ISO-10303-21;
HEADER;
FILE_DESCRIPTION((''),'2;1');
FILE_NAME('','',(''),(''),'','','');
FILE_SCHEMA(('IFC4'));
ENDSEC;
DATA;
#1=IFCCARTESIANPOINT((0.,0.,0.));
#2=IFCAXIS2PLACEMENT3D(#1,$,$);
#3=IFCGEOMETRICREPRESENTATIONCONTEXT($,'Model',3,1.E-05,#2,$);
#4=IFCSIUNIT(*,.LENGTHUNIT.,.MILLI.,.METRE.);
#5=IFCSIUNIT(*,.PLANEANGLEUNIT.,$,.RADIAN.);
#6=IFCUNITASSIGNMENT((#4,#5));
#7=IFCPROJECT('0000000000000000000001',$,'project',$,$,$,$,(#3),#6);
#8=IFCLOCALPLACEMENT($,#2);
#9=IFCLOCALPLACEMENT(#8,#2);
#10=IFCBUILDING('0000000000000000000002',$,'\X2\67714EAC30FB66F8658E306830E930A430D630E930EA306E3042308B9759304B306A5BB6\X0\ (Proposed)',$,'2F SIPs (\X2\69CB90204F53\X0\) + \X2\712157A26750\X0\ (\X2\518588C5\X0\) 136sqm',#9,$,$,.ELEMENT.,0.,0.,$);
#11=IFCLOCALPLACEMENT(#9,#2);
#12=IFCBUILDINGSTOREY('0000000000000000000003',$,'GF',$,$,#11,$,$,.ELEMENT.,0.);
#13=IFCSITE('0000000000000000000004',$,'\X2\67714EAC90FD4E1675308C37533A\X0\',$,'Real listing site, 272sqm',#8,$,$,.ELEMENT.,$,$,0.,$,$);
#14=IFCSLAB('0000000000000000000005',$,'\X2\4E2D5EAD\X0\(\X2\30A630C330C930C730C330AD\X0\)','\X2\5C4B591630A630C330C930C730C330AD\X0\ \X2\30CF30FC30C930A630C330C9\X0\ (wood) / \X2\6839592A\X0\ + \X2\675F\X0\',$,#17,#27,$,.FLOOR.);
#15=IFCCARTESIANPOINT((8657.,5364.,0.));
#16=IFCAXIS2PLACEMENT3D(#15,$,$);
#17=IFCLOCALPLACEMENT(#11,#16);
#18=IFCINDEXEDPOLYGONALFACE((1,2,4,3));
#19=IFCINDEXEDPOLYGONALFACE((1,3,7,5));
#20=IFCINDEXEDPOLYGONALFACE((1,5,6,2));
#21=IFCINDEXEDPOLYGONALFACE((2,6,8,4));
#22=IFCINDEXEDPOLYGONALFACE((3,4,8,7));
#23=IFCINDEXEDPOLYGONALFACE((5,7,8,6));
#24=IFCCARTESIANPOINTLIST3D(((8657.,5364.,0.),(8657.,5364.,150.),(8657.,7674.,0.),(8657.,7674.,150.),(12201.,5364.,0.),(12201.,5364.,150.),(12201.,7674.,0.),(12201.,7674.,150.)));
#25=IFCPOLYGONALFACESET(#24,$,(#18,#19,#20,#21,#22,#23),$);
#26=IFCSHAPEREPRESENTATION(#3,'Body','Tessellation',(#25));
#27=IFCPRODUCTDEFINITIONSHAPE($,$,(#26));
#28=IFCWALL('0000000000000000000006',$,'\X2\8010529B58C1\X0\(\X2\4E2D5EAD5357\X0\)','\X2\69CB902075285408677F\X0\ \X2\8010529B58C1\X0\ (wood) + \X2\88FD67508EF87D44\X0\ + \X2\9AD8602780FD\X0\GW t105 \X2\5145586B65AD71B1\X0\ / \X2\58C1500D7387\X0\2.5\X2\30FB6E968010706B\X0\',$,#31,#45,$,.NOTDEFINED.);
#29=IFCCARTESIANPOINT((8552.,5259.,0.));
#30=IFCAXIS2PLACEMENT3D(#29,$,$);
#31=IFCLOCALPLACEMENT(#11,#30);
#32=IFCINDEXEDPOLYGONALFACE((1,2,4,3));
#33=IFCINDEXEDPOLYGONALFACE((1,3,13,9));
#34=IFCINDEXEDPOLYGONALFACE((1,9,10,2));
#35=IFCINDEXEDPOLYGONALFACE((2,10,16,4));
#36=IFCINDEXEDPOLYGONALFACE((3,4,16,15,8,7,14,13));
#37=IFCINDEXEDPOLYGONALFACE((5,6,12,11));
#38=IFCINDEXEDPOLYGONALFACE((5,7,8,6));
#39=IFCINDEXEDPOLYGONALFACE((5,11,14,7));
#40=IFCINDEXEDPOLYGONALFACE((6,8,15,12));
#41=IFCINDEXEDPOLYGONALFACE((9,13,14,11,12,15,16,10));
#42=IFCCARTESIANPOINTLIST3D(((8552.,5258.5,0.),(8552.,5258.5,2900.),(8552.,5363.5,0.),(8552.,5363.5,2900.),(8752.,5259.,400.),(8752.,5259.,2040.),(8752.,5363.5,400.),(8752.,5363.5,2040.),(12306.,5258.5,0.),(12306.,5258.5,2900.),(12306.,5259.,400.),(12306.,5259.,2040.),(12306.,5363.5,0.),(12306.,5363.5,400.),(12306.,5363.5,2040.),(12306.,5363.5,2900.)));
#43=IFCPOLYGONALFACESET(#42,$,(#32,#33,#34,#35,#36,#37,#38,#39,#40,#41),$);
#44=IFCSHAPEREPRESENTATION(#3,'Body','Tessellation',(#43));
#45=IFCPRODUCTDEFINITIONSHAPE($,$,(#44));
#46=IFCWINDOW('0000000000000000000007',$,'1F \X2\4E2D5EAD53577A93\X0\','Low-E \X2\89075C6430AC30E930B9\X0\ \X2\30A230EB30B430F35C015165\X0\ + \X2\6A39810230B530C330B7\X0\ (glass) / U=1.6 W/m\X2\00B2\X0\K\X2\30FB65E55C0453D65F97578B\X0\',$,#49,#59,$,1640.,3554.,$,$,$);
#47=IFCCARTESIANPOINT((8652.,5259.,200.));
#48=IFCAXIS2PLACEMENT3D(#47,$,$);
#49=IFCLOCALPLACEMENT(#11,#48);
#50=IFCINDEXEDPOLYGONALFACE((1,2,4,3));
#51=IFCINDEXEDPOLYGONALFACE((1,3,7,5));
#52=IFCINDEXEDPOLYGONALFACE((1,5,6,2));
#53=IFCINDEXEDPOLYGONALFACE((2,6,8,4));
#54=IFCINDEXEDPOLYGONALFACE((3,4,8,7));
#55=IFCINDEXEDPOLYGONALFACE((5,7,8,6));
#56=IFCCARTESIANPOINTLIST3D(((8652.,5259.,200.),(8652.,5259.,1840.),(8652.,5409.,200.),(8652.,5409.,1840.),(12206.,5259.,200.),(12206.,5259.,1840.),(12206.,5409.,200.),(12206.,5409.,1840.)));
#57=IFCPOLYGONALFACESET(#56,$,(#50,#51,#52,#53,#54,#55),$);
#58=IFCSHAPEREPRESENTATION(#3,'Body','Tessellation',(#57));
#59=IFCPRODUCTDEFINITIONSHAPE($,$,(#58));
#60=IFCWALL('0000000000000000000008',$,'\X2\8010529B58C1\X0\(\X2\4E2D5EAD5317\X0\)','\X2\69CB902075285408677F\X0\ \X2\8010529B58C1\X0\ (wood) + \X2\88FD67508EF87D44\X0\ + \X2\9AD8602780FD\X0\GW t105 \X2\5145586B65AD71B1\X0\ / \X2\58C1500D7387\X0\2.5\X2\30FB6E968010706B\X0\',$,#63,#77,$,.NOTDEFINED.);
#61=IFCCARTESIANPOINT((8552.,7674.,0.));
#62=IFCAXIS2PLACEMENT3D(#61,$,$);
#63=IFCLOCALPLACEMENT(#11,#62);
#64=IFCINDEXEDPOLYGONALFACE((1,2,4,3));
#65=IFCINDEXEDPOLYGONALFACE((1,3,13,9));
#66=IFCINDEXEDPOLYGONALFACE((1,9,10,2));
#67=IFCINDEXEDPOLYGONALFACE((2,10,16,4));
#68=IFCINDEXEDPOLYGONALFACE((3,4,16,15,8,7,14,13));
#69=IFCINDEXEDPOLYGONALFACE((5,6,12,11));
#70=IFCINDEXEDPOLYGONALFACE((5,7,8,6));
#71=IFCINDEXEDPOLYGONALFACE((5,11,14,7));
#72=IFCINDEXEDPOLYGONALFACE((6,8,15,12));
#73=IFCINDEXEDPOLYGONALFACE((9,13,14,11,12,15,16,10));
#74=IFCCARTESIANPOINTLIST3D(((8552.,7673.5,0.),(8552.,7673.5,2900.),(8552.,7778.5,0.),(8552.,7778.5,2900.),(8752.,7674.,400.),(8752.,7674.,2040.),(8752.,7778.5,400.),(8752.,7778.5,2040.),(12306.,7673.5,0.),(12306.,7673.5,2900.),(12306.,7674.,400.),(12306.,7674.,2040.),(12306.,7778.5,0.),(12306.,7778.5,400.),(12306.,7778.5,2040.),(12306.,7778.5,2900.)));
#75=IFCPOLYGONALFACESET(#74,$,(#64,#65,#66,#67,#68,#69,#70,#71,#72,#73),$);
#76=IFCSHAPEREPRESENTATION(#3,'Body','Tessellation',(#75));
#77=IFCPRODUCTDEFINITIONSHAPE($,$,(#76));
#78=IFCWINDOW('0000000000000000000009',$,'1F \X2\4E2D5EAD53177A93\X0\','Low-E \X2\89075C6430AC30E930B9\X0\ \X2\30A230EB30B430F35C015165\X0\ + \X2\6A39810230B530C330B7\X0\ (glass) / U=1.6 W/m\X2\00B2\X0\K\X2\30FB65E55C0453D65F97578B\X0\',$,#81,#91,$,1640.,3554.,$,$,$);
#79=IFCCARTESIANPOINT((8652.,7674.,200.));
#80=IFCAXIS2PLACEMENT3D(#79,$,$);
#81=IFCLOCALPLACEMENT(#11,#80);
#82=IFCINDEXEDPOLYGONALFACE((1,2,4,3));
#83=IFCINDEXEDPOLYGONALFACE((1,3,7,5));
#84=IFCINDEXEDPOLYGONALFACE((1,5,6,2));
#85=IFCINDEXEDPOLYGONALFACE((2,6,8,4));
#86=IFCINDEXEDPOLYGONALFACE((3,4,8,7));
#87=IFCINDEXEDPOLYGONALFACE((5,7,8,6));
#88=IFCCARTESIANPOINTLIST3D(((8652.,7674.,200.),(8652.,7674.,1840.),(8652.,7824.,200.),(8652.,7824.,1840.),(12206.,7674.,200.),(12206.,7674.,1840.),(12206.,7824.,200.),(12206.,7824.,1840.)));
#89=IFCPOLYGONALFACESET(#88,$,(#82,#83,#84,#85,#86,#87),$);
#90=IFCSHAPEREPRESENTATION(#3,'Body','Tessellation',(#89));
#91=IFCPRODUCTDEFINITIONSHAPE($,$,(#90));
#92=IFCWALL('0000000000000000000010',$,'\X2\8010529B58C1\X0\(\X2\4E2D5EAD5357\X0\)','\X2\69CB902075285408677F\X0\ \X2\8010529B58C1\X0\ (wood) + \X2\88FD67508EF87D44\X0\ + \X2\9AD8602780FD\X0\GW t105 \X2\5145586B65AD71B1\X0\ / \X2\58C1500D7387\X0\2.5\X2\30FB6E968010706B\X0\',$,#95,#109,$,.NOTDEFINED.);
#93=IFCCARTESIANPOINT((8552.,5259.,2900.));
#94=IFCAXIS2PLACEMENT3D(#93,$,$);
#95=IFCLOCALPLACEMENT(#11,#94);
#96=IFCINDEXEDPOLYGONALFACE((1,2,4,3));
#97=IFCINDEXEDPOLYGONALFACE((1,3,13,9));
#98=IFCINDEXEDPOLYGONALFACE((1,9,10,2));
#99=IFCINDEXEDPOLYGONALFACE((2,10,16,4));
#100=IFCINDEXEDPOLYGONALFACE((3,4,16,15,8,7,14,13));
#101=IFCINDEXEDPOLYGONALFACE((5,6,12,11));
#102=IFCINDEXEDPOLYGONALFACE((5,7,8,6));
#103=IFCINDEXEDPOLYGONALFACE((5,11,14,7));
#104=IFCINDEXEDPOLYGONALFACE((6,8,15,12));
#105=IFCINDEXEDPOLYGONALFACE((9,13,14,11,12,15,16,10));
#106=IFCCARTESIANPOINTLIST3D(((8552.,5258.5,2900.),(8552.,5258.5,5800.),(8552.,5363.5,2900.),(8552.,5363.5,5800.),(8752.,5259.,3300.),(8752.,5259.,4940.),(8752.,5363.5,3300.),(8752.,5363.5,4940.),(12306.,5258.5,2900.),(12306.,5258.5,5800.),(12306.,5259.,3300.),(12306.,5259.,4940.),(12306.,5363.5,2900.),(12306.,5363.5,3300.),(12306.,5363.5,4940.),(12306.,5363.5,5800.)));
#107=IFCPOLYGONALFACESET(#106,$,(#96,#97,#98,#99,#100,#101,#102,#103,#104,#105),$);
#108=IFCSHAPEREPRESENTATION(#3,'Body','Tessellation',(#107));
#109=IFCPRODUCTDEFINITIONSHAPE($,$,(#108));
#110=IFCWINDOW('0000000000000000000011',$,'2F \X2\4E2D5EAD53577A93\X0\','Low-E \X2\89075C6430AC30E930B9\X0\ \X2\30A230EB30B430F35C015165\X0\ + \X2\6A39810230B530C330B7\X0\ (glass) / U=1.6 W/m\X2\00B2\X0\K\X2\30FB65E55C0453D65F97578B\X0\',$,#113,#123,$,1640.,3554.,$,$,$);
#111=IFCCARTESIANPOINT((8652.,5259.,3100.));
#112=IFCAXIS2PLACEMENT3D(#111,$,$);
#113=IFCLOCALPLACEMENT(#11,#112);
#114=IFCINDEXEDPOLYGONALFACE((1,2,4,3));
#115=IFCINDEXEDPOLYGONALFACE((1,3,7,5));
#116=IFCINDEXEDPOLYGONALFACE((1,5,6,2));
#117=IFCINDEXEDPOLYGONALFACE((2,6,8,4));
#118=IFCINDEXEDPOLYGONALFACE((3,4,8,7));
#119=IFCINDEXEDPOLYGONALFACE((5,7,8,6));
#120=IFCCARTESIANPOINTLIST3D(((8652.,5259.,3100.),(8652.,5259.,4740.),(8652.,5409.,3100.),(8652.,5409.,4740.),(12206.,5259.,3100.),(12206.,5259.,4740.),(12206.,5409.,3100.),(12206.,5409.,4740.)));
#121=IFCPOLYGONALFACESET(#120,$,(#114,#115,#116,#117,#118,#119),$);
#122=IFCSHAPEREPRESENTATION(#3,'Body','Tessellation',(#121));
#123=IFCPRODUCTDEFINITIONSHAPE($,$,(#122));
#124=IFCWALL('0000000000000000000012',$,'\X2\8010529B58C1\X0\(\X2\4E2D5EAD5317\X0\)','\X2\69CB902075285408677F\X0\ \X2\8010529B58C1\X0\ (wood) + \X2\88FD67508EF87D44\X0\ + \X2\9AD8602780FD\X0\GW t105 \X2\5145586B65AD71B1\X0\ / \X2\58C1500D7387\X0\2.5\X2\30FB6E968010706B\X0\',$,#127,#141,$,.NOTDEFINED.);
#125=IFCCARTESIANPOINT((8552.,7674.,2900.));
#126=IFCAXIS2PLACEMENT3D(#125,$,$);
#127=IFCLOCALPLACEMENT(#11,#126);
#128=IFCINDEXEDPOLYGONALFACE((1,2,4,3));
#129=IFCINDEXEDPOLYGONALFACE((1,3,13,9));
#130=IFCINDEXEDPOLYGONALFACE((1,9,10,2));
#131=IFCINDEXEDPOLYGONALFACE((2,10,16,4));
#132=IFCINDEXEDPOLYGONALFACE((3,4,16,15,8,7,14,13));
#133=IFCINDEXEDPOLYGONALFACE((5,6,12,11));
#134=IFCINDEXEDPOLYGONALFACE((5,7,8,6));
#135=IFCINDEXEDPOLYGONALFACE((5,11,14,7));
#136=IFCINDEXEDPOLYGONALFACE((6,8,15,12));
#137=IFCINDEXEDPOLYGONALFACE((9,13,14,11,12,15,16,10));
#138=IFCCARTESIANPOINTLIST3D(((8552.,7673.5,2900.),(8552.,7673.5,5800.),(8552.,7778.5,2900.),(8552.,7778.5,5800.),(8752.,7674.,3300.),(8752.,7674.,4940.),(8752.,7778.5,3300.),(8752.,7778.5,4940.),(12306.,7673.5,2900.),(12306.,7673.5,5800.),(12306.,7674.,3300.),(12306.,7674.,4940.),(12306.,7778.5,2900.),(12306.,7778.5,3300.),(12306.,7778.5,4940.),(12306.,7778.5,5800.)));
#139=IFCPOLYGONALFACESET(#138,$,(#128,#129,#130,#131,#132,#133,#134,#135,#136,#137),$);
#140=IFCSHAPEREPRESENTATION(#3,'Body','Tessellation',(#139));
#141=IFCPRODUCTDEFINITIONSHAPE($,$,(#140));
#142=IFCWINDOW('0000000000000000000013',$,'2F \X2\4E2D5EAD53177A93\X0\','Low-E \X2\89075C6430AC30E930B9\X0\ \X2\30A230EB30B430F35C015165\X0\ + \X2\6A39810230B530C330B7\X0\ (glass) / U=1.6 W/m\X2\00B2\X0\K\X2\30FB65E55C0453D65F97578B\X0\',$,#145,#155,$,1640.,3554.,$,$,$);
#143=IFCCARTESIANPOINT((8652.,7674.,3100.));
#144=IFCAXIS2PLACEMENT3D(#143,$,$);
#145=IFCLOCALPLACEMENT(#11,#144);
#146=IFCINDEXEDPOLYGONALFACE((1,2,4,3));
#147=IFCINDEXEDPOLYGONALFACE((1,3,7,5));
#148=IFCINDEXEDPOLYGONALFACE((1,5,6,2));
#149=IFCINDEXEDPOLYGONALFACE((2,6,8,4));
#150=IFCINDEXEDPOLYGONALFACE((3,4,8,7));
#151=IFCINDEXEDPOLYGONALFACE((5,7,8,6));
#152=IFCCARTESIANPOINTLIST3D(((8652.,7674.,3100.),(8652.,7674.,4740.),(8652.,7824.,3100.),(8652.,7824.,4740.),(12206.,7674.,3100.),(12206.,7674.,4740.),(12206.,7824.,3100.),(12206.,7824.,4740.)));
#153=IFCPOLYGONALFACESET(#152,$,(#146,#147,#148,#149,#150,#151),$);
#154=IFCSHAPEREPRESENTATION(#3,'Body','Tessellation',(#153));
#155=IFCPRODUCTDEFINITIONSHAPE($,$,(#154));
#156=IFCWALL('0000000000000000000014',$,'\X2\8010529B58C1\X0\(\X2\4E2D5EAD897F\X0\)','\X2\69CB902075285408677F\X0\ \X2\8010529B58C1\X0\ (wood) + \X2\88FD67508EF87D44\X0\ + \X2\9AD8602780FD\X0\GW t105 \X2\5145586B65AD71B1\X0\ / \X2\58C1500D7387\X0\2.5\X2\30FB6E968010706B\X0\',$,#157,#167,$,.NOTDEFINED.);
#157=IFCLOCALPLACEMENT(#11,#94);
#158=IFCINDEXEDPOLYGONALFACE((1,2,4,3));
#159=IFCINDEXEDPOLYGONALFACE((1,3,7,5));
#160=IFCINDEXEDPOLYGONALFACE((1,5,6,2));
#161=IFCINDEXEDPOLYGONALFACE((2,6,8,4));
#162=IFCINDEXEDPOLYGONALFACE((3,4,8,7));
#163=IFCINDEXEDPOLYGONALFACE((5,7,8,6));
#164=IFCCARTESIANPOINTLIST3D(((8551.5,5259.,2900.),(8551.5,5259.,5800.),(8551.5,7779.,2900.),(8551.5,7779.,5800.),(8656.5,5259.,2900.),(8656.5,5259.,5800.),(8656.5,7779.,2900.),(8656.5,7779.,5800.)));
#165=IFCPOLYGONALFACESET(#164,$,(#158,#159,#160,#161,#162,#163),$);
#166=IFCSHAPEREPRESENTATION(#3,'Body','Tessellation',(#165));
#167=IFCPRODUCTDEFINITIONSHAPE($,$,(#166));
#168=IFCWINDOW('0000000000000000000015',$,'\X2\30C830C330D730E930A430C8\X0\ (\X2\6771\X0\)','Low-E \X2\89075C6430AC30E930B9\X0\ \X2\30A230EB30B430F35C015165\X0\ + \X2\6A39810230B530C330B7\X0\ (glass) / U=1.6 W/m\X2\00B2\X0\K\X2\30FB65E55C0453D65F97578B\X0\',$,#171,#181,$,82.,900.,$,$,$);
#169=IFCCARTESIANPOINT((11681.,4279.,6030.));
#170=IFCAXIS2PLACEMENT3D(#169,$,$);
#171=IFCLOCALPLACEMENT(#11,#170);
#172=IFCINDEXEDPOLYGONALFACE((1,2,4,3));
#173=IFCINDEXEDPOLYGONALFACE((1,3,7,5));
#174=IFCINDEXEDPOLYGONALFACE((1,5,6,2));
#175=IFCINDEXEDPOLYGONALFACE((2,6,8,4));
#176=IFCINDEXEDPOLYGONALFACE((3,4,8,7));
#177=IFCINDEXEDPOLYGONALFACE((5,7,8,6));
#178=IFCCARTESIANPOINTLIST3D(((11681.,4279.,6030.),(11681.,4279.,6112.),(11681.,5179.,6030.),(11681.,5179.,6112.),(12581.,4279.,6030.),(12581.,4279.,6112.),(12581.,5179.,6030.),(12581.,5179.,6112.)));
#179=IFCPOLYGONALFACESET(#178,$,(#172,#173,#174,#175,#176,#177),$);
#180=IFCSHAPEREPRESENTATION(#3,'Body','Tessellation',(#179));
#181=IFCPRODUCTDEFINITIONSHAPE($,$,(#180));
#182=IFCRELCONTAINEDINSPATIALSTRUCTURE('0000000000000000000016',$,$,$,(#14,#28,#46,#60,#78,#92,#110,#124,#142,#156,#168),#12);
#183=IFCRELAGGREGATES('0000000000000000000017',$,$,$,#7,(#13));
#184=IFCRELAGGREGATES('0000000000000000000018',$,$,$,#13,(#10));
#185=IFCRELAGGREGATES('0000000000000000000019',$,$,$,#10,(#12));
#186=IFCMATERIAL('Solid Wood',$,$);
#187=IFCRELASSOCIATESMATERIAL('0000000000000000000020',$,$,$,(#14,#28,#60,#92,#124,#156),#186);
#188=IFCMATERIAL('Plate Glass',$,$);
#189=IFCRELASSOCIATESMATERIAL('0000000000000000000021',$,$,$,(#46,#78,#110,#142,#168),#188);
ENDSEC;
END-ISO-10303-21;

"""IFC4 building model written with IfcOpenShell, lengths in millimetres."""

from ifc_helpers import new_model, si_unit, frame, frame_2d, origin, place, context, project, spatial, rectangle, extrude, material, element, fill, save


model = new_model("IFC4")

# Units and contexts
model_context = context("Model", 3, precision=1e-05, world=origin())
ifc_project = project(units=[si_unit("LENGTHUNIT", "METRE", prefix="MILLI"), si_unit("PLANEANGLEUNIT", "RADIAN")], contexts=[model_context])

# Site, building, storey
site_placement = place(None, origin())
site = spatial("IfcSite", under=ifc_project, at=site_placement, Name="東京都世田谷区", ObjectType="Real listing site, 272sqm", CompositionType="ELEMENT", RefElevation=0.0)
building_placement = place(site_placement, origin())
building = spatial("IfcBuilding", under=site, at=building_placement, Name="東京・書斎とライブラリのある静かな家 (Proposed)", ObjectType="2F SIPs (構造体) + 無垢材 (内装) 136sqm", CompositionType="ELEMENT", ElevationOfRefHeight=0.0, ElevationOfTerrain=0.0)
storey_placement = place(building_placement, origin())
storey = spatial("IfcBuildingStorey", under=building, at=storey_placement, Name="GF", CompositionType="ELEMENT", Elevation=0.0)

# Slab
ifc_material_1 = material(Name="Solid Wood")
slab_placement = place(storey_placement, frame((8657.0, 5364.0, 0.0)))
element("IfcSlab", 1, at=slab_placement, inside=storey, material=ifc_material_1, Name="中庭(ウッドデッキ)", Description="屋外ウッドデッキ ハードウッド (wood) / 根太 + 束", PredefinedType="FLOOR", context=model_context, shape_type="SweptSolid", body=[
    extrude(rectangle(XDim=3544.0, YDim=2310.0, at=frame_2d((1772.0, 1155.0))), frame((8657.0, 5364.0, 0.0)), (0.0, 0.0, 1.0), 150.0),
])

# Walls, openings, windows
wall_1_placement = place(storey_placement, frame((8552.0, 5259.0, 0.0)))
wall_1 = element("IfcWall", 2, at=wall_1_placement, inside=storey, material=ifc_material_1, Name="耐力壁(中庭南)", Description="構造用合板 耐力壁 (wood) + 製材軸組 + 高性能GW t105 充填断熱 / 壁倍率2.5・準耐火", PredefinedType="NOTDEFINED", context=model_context, shape_type="SweptSolid", body=[
    extrude(rectangle(XDim=3754.0, YDim=105.0, at=frame_2d((1877.0, 52.0))), frame((8552.0, 5259.0, 0.0)), (0.0, 0.0, 1.0), 2900.0),
])
opening_1_placement = place(storey_placement, frame((8652.0, 5259.0, 200.0)))
opening_1 = element("IfcOpeningElement", 3, at=opening_1_placement, cuts=wall_1, PredefinedType="NOTDEFINED", context=model_context, shape_type="SweptSolid", body=[
    extrude(rectangle(XDim=3554.0, YDim=150.0, at=frame_2d((1777.0, 75.0))), frame((8652.0, 5259.0, 200.0)), (0.0, 0.0, 1.0), 1640.0),
])
ifc_material_2 = material(Name="Plate Glass")
window_1_placement = place(storey_placement, frame((8652.0, 5259.0, 200.0)))
window_1 = element("IfcWindow", 4, at=window_1_placement, inside=storey, material=ifc_material_2, Name="1F 中庭南窓", Description="Low-E 複層ガラス アルゴン封入 + 樹脂サッシ (glass) / U=1.6 W/m²K・日射取得型", OverallHeight=1640.0, OverallWidth=3554.0, context=model_context, shape_type="SweptSolid", body=[
    extrude(rectangle(XDim=3554.0, YDim=150.0, at=frame_2d((1777.0, 75.0))), frame((8652.0, 5259.0, 200.0)), (0.0, 0.0, 1.0), 1640.0),
])
fill(opening_1, window_1)
wall_2_placement = place(storey_placement, frame((8552.0, 7674.0, 0.0)))
wall_2 = element("IfcWall", 5, at=wall_2_placement, inside=storey, material=ifc_material_1, Name="耐力壁(中庭北)", Description="構造用合板 耐力壁 (wood) + 製材軸組 + 高性能GW t105 充填断熱 / 壁倍率2.5・準耐火", PredefinedType="NOTDEFINED", context=model_context, shape_type="SweptSolid", body=[
    extrude(rectangle(XDim=3754.0, YDim=105.0, at=frame_2d((1877.0, 52.0))), frame((8552.0, 7674.0, 0.0)), (0.0, 0.0, 1.0), 2900.0),
])
opening_2_placement = place(storey_placement, frame((8652.0, 7674.0, 200.0)))
opening_2 = element("IfcOpeningElement", 6, at=opening_2_placement, cuts=wall_2, PredefinedType="NOTDEFINED", context=model_context, shape_type="SweptSolid", body=[
    extrude(rectangle(XDim=3554.0, YDim=150.0, at=frame_2d((1777.0, 75.0))), frame((8652.0, 7674.0, 200.0)), (0.0, 0.0, 1.0), 1640.0),
])
window_2_placement = place(storey_placement, frame((8652.0, 7674.0, 200.0)))
window_2 = element("IfcWindow", 7, at=window_2_placement, inside=storey, material=ifc_material_2, Name="1F 中庭北窓", Description="Low-E 複層ガラス アルゴン封入 + 樹脂サッシ (glass) / U=1.6 W/m²K・日射取得型", OverallHeight=1640.0, OverallWidth=3554.0, context=model_context, shape_type="SweptSolid", body=[
    extrude(rectangle(XDim=3554.0, YDim=150.0, at=frame_2d((1777.0, 75.0))), frame((8652.0, 7674.0, 200.0)), (0.0, 0.0, 1.0), 1640.0),
])
fill(opening_2, window_2)

# Walls, openings, windows
wall_3_placement = place(storey_placement, frame((8552.0, 5259.0, 2900.0)))
wall_3 = element("IfcWall", 8, at=wall_3_placement, inside=storey, material=ifc_material_1, Name="耐力壁(中庭南)", Description="構造用合板 耐力壁 (wood) + 製材軸組 + 高性能GW t105 充填断熱 / 壁倍率2.5・準耐火", PredefinedType="NOTDEFINED", context=model_context, shape_type="SweptSolid", body=[
    extrude(rectangle(XDim=3754.0, YDim=105.0, at=frame_2d((1877.0, 52.0))), frame((8552.0, 5259.0, 2900.0)), (0.0, 0.0, 1.0), 2900.0),
])
opening_3_placement = place(storey_placement, frame((8652.0, 5259.0, 3100.0)))
opening_3 = element("IfcOpeningElement", 9, at=opening_3_placement, cuts=wall_3, PredefinedType="NOTDEFINED", context=model_context, shape_type="SweptSolid", body=[
    extrude(rectangle(XDim=3554.0, YDim=150.0, at=frame_2d((1777.0, 75.0))), frame((8652.0, 5259.0, 3100.0)), (0.0, 0.0, 1.0), 1640.0),
])
window_3_placement = place(storey_placement, frame((8652.0, 5259.0, 3100.0)))
window_3 = element("IfcWindow", 10, at=window_3_placement, inside=storey, material=ifc_material_2, Name="2F 中庭南窓", Description="Low-E 複層ガラス アルゴン封入 + 樹脂サッシ (glass) / U=1.6 W/m²K・日射取得型", OverallHeight=1640.0, OverallWidth=3554.0, context=model_context, shape_type="SweptSolid", body=[
    extrude(rectangle(XDim=3554.0, YDim=150.0, at=frame_2d((1777.0, 75.0))), frame((8652.0, 5259.0, 3100.0)), (0.0, 0.0, 1.0), 1640.0),
])
fill(opening_3, window_3)
wall_4_placement = place(storey_placement, frame((8552.0, 7674.0, 2900.0)))
wall_4 = element("IfcWall", 11, at=wall_4_placement, inside=storey, material=ifc_material_1, Name="耐力壁(中庭北)", Description="構造用合板 耐力壁 (wood) + 製材軸組 + 高性能GW t105 充填断熱 / 壁倍率2.5・準耐火", PredefinedType="NOTDEFINED", context=model_context, shape_type="SweptSolid", body=[
    extrude(rectangle(XDim=3754.0, YDim=105.0, at=frame_2d((1877.0, 52.0))), frame((8552.0, 7674.0, 2900.0)), (0.0, 0.0, 1.0), 2900.0),
])
opening_4_placement = place(storey_placement, frame((8652.0, 7674.0, 3100.0)))
opening_4 = element("IfcOpeningElement", 12, at=opening_4_placement, cuts=wall_4, PredefinedType="NOTDEFINED", context=model_context, shape_type="SweptSolid", body=[
    extrude(rectangle(XDim=3554.0, YDim=150.0, at=frame_2d((1777.0, 75.0))), frame((8652.0, 7674.0, 3100.0)), (0.0, 0.0, 1.0), 1640.0),
])
window_4_placement = place(storey_placement, frame((8652.0, 7674.0, 3100.0)))
window_4 = element("IfcWindow", 13, at=window_4_placement, inside=storey, material=ifc_material_2, Name="2F 中庭北窓", Description="Low-E 複層ガラス アルゴン封入 + 樹脂サッシ (glass) / U=1.6 W/m²K・日射取得型", OverallHeight=1640.0, OverallWidth=3554.0, context=model_context, shape_type="SweptSolid", body=[
    extrude(rectangle(XDim=3554.0, YDim=150.0, at=frame_2d((1777.0, 75.0))), frame((8652.0, 7674.0, 3100.0)), (0.0, 0.0, 1.0), 1640.0),
])
fill(opening_4, window_4)

# Wall
wall_5_placement = place(storey_placement, frame((8552.0, 5259.0, 2900.0)))
element("IfcWall", 14, at=wall_5_placement, inside=storey, material=ifc_material_1, Name="耐力壁(中庭西)", Description="構造用合板 耐力壁 (wood) + 製材軸組 + 高性能GW t105 充填断熱 / 壁倍率2.5・準耐火", PredefinedType="NOTDEFINED", context=model_context, shape_type="SweptSolid", body=[
    extrude(rectangle(XDim=105.0, YDim=2520.0, at=frame_2d((52.0, 1260.0))), frame((8552.0, 5259.0, 2900.0)), (0.0, 0.0, 1.0), 2900.0),
])

# Window
window_5_placement = place(storey_placement, frame((11681.0, 4279.0, 6030.0)))
element("IfcWindow", 15, at=window_5_placement, inside=storey, material=ifc_material_2, Name="トップライト (東)", Description="Low-E 複層ガラス アルゴン封入 + 樹脂サッシ (glass) / U=1.6 W/m²K・日射取得型", OverallHeight=82.0, OverallWidth=900.0, context=model_context, shape_type="SweptSolid", body=[
    extrude(rectangle(XDim=900.0, YDim=900.0, at=frame_2d((450.0, 450.0))), frame((11681.0, 4279.0, 6030.0)), (0.0, 0.0, 1.0), 82.0),
])

save(model, "model.ifc")
